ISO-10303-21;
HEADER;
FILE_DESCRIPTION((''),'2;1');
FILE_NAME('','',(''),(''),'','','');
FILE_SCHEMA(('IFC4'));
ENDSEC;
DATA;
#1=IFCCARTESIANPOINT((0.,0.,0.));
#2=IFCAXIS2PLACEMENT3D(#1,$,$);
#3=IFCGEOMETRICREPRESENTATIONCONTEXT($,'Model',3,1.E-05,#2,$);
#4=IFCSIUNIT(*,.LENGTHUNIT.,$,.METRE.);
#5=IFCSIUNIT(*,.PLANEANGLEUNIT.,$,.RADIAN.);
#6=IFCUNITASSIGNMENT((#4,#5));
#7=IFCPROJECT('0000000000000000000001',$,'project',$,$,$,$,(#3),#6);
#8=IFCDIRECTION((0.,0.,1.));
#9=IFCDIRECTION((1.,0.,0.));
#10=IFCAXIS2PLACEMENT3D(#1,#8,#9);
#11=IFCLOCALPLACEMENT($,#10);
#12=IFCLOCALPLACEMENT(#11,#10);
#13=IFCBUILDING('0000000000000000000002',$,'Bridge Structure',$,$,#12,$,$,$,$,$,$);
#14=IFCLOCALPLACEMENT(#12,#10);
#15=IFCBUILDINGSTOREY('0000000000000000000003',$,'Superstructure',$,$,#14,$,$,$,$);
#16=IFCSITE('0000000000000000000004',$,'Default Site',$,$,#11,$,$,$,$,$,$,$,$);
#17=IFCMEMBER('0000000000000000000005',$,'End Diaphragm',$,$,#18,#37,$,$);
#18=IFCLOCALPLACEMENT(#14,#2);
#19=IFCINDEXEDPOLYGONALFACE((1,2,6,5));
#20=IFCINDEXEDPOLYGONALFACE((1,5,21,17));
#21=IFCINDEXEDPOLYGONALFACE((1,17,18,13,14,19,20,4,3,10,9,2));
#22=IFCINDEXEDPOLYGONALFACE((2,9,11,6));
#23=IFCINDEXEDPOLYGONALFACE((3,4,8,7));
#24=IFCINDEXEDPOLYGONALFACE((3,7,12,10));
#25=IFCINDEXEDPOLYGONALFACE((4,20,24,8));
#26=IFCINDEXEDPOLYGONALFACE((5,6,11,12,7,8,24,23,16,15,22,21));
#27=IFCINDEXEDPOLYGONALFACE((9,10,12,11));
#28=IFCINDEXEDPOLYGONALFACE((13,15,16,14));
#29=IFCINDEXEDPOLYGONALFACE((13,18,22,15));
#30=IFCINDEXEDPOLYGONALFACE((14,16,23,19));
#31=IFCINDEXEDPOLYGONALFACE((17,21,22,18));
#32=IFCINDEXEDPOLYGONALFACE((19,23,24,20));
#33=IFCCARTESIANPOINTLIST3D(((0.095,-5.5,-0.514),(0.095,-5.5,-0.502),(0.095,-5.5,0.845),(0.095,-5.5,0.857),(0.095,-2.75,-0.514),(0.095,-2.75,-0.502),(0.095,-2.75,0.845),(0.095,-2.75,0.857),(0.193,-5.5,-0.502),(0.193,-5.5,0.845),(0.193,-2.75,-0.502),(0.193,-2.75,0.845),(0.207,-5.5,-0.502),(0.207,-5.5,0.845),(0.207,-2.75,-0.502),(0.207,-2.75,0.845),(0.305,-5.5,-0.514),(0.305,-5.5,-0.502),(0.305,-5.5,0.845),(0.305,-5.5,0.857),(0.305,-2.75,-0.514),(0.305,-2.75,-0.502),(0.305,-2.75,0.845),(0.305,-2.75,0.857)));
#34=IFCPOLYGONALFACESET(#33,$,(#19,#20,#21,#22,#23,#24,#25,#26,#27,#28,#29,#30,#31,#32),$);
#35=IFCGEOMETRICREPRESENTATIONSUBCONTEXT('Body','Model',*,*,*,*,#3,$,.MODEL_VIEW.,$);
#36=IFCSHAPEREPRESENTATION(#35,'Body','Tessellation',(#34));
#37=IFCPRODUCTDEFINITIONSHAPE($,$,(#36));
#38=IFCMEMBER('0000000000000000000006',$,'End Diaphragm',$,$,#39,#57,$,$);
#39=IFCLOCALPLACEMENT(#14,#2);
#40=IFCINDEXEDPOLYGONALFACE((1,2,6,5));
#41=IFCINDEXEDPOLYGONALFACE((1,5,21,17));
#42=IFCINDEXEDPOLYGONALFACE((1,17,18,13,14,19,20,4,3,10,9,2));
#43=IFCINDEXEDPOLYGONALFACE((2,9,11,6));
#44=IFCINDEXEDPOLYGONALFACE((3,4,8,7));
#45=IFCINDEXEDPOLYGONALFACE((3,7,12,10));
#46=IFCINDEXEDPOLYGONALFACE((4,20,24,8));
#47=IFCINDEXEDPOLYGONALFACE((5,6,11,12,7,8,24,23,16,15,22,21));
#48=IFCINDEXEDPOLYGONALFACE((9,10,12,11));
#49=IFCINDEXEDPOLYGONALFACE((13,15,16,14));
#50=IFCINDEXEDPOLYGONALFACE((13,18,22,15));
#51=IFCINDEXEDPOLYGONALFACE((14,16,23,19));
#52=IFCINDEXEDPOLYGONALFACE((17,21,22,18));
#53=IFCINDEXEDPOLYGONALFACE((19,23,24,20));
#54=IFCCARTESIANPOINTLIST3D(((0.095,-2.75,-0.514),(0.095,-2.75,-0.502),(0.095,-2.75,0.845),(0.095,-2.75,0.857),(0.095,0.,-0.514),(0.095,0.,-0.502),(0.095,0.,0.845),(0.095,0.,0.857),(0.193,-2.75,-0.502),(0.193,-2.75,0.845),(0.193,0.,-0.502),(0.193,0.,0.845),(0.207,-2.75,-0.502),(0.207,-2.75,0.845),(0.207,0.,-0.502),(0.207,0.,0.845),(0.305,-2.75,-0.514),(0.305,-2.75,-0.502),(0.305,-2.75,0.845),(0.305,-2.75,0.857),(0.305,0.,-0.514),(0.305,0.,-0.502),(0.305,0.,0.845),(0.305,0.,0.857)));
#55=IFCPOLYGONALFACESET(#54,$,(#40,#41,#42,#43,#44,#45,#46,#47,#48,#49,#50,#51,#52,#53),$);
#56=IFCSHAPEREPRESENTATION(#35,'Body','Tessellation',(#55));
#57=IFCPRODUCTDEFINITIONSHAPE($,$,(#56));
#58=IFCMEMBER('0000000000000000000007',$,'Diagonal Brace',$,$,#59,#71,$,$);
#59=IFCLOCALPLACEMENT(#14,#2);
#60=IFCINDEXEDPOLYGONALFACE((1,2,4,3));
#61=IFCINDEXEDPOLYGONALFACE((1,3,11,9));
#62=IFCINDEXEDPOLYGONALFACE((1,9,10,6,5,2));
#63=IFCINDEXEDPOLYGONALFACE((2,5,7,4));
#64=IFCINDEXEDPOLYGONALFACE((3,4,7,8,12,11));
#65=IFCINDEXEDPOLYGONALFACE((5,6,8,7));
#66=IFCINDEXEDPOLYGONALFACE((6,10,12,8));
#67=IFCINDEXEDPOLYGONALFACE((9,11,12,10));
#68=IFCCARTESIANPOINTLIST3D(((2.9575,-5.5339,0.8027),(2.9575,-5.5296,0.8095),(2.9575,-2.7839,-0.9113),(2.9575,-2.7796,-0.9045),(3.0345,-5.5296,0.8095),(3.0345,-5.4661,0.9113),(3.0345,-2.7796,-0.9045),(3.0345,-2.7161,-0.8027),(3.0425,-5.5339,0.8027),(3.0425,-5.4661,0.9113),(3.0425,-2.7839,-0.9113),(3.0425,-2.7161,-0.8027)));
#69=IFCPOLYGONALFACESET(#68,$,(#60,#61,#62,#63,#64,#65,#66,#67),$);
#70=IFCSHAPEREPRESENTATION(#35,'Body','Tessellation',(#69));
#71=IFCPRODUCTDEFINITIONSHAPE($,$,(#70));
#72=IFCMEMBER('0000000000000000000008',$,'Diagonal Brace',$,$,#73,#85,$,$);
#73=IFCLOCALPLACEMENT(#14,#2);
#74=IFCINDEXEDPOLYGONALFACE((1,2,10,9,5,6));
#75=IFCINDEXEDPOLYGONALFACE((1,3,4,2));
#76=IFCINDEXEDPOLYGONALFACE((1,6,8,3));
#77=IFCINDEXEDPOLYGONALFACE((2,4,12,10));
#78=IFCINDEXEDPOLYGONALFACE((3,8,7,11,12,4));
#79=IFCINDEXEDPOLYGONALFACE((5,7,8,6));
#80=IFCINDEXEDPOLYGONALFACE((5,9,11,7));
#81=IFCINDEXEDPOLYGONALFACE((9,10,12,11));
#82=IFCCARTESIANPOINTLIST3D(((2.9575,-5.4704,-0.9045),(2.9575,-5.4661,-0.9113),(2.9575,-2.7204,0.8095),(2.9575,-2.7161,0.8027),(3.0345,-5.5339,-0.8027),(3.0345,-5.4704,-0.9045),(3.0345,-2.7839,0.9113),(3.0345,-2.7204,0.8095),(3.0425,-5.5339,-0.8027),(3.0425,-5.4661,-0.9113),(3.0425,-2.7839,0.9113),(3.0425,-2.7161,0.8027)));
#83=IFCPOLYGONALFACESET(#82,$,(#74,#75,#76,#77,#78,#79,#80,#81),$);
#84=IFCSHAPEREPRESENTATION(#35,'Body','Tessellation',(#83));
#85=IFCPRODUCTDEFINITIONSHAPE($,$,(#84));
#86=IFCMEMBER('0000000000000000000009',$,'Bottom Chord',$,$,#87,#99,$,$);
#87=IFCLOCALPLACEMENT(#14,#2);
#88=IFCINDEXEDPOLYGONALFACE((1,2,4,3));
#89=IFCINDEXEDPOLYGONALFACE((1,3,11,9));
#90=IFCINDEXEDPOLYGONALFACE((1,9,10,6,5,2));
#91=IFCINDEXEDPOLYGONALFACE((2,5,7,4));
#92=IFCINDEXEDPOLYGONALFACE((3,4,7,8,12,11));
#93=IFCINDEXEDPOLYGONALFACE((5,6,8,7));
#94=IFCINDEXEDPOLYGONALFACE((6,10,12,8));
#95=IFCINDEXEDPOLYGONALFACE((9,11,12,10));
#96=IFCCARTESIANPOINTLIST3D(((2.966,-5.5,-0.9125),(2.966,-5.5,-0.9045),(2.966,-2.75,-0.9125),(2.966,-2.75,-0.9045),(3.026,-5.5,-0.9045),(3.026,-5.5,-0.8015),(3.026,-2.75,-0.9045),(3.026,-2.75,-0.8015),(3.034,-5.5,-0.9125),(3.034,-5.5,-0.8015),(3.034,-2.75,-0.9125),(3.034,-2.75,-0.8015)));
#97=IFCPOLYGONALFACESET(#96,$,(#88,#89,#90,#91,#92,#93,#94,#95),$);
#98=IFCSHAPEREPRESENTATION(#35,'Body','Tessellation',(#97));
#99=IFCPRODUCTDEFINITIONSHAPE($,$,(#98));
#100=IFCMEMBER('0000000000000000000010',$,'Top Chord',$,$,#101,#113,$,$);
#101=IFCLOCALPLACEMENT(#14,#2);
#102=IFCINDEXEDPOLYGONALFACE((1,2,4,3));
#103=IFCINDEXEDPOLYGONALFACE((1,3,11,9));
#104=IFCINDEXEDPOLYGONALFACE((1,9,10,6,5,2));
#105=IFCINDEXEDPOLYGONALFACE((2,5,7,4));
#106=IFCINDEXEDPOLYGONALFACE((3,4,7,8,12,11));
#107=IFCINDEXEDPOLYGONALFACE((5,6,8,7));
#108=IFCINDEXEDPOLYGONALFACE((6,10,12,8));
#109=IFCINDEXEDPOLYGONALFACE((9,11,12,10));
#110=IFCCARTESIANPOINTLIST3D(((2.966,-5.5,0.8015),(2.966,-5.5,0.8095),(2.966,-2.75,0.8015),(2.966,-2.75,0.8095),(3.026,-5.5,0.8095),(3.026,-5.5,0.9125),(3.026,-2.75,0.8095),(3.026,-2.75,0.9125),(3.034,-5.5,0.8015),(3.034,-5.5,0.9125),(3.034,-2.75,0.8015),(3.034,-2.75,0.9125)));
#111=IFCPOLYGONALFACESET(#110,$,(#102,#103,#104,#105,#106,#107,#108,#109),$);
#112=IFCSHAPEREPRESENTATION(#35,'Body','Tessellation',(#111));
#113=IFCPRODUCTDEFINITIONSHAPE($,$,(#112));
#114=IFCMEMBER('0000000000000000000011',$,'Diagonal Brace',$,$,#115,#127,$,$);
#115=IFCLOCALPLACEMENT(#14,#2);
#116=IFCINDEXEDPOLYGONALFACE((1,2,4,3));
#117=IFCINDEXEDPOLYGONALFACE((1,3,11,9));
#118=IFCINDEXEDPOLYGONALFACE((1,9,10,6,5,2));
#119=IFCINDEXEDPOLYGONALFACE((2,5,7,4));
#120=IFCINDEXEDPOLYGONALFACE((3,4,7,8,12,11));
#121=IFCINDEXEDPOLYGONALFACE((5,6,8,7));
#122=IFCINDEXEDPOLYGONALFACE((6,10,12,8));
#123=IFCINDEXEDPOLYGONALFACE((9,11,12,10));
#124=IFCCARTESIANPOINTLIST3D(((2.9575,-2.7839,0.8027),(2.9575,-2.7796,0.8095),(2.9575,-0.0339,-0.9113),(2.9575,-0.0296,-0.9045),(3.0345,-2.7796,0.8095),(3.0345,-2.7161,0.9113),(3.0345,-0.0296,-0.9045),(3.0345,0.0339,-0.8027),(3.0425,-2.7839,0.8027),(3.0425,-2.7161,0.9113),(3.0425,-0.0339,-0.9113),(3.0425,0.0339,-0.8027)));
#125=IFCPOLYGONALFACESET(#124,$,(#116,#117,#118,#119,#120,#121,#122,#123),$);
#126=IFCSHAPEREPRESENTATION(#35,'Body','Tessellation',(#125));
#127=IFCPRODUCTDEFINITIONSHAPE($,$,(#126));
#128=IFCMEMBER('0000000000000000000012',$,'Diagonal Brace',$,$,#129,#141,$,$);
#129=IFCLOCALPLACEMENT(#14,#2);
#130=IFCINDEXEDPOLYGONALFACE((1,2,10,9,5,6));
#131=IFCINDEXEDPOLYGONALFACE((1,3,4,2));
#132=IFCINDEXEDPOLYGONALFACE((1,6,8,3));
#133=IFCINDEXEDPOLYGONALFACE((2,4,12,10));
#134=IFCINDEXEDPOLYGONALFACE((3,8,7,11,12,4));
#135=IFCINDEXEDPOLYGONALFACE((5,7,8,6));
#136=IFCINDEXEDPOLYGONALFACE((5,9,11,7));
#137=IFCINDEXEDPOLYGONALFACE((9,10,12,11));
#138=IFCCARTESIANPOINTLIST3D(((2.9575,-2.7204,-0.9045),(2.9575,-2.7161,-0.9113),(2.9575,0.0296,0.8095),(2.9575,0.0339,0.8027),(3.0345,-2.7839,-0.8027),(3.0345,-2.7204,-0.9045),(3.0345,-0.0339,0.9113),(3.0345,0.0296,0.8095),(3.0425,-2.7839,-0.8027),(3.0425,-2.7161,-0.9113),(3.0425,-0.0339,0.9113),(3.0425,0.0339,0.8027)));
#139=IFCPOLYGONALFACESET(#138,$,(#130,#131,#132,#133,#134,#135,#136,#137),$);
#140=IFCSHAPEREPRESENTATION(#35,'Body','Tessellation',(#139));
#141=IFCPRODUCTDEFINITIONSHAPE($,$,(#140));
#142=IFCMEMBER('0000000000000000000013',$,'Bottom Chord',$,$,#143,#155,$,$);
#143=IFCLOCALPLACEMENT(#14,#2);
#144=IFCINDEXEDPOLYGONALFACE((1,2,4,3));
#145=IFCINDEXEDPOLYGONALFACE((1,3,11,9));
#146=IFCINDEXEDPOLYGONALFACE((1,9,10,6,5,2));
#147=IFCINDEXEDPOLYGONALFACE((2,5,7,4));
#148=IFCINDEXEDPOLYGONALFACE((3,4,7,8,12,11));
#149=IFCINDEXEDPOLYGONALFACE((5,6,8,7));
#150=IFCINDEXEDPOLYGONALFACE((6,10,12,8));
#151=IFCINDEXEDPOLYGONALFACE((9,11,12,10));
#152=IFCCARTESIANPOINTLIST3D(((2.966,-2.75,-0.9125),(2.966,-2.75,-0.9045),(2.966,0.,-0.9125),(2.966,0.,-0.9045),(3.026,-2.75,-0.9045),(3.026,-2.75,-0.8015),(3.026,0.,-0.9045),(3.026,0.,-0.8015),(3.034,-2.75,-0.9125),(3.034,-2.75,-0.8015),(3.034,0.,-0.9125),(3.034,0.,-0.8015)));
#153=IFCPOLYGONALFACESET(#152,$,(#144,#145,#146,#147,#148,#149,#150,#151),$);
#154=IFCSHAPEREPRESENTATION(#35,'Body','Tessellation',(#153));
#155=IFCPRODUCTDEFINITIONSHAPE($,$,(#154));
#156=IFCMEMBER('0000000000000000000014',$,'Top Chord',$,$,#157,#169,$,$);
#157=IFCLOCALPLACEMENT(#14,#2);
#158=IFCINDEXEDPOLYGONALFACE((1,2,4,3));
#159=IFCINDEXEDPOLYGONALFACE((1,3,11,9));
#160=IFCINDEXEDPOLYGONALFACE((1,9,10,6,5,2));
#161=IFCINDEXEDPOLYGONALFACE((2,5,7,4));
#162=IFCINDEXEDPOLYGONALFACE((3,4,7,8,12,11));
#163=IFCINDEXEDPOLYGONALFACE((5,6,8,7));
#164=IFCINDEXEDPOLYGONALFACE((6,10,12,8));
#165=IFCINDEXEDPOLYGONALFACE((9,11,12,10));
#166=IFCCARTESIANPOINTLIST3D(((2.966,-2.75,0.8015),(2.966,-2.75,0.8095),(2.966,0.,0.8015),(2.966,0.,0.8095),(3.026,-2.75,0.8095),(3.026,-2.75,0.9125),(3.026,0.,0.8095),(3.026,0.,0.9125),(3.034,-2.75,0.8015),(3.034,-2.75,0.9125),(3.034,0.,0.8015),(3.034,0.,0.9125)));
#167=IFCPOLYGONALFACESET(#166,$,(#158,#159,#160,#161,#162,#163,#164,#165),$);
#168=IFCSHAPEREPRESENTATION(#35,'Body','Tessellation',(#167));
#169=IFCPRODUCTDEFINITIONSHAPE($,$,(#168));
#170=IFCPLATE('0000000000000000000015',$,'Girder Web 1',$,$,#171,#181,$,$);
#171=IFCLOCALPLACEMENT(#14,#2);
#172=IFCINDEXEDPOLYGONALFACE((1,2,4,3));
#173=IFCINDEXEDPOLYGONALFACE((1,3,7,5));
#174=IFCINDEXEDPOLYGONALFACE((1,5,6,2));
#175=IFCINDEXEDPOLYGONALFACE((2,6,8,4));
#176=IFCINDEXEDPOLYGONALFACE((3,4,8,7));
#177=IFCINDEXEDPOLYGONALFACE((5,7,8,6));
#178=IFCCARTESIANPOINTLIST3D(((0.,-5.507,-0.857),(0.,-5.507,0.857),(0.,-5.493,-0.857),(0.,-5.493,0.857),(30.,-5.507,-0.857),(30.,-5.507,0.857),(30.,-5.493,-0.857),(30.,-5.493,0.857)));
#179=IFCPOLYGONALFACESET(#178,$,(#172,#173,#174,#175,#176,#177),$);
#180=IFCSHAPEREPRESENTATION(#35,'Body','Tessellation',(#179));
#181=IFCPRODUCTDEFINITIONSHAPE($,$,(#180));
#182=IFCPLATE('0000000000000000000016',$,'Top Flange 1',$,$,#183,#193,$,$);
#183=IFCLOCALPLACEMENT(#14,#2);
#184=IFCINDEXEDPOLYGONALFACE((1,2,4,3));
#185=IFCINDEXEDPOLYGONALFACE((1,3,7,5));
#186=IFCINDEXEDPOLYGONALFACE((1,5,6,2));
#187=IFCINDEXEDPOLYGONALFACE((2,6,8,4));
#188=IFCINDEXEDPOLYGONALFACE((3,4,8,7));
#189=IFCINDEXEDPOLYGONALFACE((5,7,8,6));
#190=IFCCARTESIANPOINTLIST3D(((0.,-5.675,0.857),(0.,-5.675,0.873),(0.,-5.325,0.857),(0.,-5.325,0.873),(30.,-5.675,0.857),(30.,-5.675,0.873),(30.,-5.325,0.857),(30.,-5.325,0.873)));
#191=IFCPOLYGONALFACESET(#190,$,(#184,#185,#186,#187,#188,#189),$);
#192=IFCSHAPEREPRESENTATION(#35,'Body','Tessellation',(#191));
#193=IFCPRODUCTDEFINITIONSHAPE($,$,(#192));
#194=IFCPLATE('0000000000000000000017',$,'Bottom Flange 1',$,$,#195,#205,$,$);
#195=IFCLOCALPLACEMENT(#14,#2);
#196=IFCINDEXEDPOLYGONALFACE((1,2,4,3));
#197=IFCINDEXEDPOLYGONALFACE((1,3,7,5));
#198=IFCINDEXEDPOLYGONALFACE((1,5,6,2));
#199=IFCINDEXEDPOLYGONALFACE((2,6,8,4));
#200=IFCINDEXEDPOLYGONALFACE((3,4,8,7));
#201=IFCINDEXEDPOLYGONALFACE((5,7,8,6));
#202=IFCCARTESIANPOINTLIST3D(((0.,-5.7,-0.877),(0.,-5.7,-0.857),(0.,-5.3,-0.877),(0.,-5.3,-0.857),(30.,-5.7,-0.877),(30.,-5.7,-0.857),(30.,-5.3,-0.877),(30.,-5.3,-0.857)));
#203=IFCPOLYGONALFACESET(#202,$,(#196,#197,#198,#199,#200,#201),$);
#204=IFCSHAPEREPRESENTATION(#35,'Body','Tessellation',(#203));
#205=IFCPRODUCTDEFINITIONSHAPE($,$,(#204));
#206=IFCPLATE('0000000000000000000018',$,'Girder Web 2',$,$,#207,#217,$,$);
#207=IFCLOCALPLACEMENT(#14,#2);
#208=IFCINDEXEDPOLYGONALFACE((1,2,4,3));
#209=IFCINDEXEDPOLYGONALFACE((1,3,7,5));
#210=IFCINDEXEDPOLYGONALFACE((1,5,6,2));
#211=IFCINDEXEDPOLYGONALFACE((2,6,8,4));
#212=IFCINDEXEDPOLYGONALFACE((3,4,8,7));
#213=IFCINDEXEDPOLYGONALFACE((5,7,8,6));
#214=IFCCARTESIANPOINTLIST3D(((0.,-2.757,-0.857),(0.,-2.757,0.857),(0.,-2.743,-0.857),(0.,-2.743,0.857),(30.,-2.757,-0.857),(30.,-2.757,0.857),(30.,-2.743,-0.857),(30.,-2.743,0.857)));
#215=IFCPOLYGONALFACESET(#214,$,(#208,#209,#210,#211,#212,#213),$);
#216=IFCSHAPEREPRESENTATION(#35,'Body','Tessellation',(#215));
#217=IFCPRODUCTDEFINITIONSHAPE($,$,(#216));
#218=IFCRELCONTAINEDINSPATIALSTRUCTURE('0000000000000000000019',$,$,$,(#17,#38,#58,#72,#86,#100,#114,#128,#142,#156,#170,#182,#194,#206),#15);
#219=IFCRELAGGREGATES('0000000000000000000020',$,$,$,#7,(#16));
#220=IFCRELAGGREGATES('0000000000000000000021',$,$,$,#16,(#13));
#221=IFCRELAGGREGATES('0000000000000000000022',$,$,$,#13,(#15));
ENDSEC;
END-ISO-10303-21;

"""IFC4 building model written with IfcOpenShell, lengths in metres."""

from ifc_helpers import new_model, si_unit, frame, origin, origin_with_axes, origin_2d_with_axis, place, context, subcontext, project, spatial, rectangle, i_section, l_section, extrude, element, save


model = new_model("IFC4")

# Units and contexts
model_context = context("Model", 3, precision=1e-05, world=origin())
body_context = subcontext(model_context, "Body", "Model", "MODEL_VIEW")
ifc_project = project(units=[si_unit("LENGTHUNIT", "METRE"), si_unit("PLANEANGLEUNIT", "RADIAN")], contexts=[model_context])

# Site, building, storey
site_placement = place(None, origin_with_axes())
site = spatial("IfcSite", under=ifc_project, at=site_placement, Name="Default Site")
building_placement = place(site_placement, origin_with_axes())
building = spatial("IfcBuilding", under=site, at=building_placement, Name="Bridge Structure")
storey_placement = place(building_placement, origin_with_axes())
storey = spatial("IfcBuildingStorey", under=building, at=storey_placement, Name="Superstructure")

# Members
for number, where, z_axis, x_axis, name in (
    (1, (0.2, -5.5, 0.1715), (0.0, 1.0, 0.0), (-1.0, 0.0, 0.0), "End Diaphragm"),
    (2, (0.2, -2.75, 0.1715), (0.0, 1.0, 0.0), (-1.0, 0.0, 0.0), "End Diaphragm"),
):
    element("IfcMember", number, at=place(storey_placement, frame(where, z_axis=z_axis, x_axis=x_axis)), inside=storey, Name=name, context=body_context, shape_type="SweptSolid", body=[
        extrude(i_section(OverallWidth=0.21, OverallDepth=1.371, WebThickness=0.014, FlangeThickness=0.012, at=origin_2d_with_axis()), origin_with_axes(), (0.0, 0.0, 1.0), 2.75),
    ])
for number, where, z_axis, x_axis, name in (
    (3, (3.0, -5.5, 0.857), (0.0, 0.848656, -0.528944), (-1.0, 0.0, 0.0), "Diagonal Brace"),
    (4, (3.0, -5.5, -0.857), (0.0, 0.848656, 0.528944), (-1.0, 0.0, 0.0), "Diagonal Brace"),
):
    element("IfcMember", number, at=place(storey_placement, frame(where, z_axis=z_axis, x_axis=x_axis)), inside=storey, Name=name, context=body_context, shape_type="SweptSolid", body=[
        extrude(l_section(Depth=0.128, Width=0.085, Thickness=0.008, at=origin_2d_with_axis()), origin_with_axes(), (0.0, 0.0, 1.0), 3.2404),
    ])
for number, where, z_axis, x_axis, name in (
    (5, (3.0, -5.5, -0.857), (0.0, 1.0, 0.0), (-1.0, 0.0, 0.0), "Bottom Chord"),
    (6, (3.0, -5.5, 0.857), (0.0, 1.0, 0.0), (-1.0, 0.0, 0.0), "Top Chord"),
):
    element("IfcMember", number, at=place(storey_placement, frame(where, z_axis=z_axis, x_axis=x_axis)), inside=storey, Name=name, context=body_context, shape_type="SweptSolid", body=[
        extrude(l_section(Depth=0.111, Width=0.068, Thickness=0.008, at=origin_2d_with_axis()), origin_with_axes(), (0.0, 0.0, 1.0), 2.75),
    ])
for number, where, z_axis, x_axis, name in (
    (7, (3.0, -2.75, 0.857), (0.0, 0.848656, -0.528944), (-1.0, 0.0, 0.0), "Diagonal Brace"),
    (8, (3.0, -2.75, -0.857), (0.0, 0.848656, 0.528944), (-1.0, 0.0, 0.0), "Diagonal Brace"),
):
    element("IfcMember", number, at=place(storey_placement, frame(where, z_axis=z_axis, x_axis=x_axis)), inside=storey, Name=name, context=body_context, shape_type="SweptSolid", body=[
        extrude(l_section(Depth=0.128, Width=0.085, Thickness=0.008, at=origin_2d_with_axis()), origin_with_axes(), (0.0, 0.0, 1.0), 3.2404),
    ])
for number, where, z_axis, x_axis, name in (
    (9, (3.0, -2.75, -0.857), (0.0, 1.0, 0.0), (-1.0, 0.0, 0.0), "Bottom Chord"),
    (10, (3.0, -2.75, 0.857), (0.0, 1.0, 0.0), (-1.0, 0.0, 0.0), "Top Chord"),
):
    element("IfcMember", number, at=place(storey_placement, frame(where, z_axis=z_axis, x_axis=x_axis)), inside=storey, Name=name, context=body_context, shape_type="SweptSolid", body=[
        extrude(l_section(Depth=0.111, Width=0.068, Thickness=0.008, at=origin_2d_with_axis()), origin_with_axes(), (0.0, 0.0, 1.0), 2.75),
    ])

# Plates
plate_1_placement = place(storey_placement, frame((0.0, -5.5, 0.0), z_axis=(1.0, 0.0, 0.0), x_axis=(0.0, 1.0, 0.0)))
element("IfcPlate", 11, at=plate_1_placement, inside=storey, Name="Girder Web 1", context=body_context, shape_type="SweptSolid", body=[
    extrude(rectangle(XDim=0.014, YDim=1.714, at=origin_2d_with_axis()), origin_with_axes(), (0.0, 0.0, 1.0), 30.0),
])
plate_2_placement = place(storey_placement, frame((0.0, -5.5, 0.865), z_axis=(1.0, 0.0, 0.0), x_axis=(0.0, 1.0, 0.0)))
element("IfcPlate", 12, at=plate_2_placement, inside=storey, Name="Top Flange 1", context=body_context, shape_type="SweptSolid", body=[
    extrude(rectangle(XDim=0.35, YDim=0.016, at=origin_2d_with_axis()), origin_with_axes(), (0.0, 0.0, 1.0), 30.0),
])
plate_3_placement = place(storey_placement, frame((0.0, -5.5, -0.867), z_axis=(1.0, 0.0, 0.0), x_axis=(0.0, 1.0, 0.0)))
element("IfcPlate", 13, at=plate_3_placement, inside=storey, Name="Bottom Flange 1", context=body_context, shape_type="SweptSolid", body=[
    extrude(rectangle(XDim=0.4, YDim=0.02, at=origin_2d_with_axis()), origin_with_axes(), (0.0, 0.0, 1.0), 30.0),
])
plate_4_placement = place(storey_placement, frame((0.0, -2.75, 0.0), z_axis=(1.0, 0.0, 0.0), x_axis=(0.0, 1.0, 0.0)))
element("IfcPlate", 14, at=plate_4_placement, inside=storey, Name="Girder Web 2", context=body_context, shape_type="SweptSolid", body=[
    extrude(rectangle(XDim=0.014, YDim=1.714, at=origin_2d_with_axis()), origin_with_axes(), (0.0, 0.0, 1.0), 30.0),
])

save(model, "model.ifc")
